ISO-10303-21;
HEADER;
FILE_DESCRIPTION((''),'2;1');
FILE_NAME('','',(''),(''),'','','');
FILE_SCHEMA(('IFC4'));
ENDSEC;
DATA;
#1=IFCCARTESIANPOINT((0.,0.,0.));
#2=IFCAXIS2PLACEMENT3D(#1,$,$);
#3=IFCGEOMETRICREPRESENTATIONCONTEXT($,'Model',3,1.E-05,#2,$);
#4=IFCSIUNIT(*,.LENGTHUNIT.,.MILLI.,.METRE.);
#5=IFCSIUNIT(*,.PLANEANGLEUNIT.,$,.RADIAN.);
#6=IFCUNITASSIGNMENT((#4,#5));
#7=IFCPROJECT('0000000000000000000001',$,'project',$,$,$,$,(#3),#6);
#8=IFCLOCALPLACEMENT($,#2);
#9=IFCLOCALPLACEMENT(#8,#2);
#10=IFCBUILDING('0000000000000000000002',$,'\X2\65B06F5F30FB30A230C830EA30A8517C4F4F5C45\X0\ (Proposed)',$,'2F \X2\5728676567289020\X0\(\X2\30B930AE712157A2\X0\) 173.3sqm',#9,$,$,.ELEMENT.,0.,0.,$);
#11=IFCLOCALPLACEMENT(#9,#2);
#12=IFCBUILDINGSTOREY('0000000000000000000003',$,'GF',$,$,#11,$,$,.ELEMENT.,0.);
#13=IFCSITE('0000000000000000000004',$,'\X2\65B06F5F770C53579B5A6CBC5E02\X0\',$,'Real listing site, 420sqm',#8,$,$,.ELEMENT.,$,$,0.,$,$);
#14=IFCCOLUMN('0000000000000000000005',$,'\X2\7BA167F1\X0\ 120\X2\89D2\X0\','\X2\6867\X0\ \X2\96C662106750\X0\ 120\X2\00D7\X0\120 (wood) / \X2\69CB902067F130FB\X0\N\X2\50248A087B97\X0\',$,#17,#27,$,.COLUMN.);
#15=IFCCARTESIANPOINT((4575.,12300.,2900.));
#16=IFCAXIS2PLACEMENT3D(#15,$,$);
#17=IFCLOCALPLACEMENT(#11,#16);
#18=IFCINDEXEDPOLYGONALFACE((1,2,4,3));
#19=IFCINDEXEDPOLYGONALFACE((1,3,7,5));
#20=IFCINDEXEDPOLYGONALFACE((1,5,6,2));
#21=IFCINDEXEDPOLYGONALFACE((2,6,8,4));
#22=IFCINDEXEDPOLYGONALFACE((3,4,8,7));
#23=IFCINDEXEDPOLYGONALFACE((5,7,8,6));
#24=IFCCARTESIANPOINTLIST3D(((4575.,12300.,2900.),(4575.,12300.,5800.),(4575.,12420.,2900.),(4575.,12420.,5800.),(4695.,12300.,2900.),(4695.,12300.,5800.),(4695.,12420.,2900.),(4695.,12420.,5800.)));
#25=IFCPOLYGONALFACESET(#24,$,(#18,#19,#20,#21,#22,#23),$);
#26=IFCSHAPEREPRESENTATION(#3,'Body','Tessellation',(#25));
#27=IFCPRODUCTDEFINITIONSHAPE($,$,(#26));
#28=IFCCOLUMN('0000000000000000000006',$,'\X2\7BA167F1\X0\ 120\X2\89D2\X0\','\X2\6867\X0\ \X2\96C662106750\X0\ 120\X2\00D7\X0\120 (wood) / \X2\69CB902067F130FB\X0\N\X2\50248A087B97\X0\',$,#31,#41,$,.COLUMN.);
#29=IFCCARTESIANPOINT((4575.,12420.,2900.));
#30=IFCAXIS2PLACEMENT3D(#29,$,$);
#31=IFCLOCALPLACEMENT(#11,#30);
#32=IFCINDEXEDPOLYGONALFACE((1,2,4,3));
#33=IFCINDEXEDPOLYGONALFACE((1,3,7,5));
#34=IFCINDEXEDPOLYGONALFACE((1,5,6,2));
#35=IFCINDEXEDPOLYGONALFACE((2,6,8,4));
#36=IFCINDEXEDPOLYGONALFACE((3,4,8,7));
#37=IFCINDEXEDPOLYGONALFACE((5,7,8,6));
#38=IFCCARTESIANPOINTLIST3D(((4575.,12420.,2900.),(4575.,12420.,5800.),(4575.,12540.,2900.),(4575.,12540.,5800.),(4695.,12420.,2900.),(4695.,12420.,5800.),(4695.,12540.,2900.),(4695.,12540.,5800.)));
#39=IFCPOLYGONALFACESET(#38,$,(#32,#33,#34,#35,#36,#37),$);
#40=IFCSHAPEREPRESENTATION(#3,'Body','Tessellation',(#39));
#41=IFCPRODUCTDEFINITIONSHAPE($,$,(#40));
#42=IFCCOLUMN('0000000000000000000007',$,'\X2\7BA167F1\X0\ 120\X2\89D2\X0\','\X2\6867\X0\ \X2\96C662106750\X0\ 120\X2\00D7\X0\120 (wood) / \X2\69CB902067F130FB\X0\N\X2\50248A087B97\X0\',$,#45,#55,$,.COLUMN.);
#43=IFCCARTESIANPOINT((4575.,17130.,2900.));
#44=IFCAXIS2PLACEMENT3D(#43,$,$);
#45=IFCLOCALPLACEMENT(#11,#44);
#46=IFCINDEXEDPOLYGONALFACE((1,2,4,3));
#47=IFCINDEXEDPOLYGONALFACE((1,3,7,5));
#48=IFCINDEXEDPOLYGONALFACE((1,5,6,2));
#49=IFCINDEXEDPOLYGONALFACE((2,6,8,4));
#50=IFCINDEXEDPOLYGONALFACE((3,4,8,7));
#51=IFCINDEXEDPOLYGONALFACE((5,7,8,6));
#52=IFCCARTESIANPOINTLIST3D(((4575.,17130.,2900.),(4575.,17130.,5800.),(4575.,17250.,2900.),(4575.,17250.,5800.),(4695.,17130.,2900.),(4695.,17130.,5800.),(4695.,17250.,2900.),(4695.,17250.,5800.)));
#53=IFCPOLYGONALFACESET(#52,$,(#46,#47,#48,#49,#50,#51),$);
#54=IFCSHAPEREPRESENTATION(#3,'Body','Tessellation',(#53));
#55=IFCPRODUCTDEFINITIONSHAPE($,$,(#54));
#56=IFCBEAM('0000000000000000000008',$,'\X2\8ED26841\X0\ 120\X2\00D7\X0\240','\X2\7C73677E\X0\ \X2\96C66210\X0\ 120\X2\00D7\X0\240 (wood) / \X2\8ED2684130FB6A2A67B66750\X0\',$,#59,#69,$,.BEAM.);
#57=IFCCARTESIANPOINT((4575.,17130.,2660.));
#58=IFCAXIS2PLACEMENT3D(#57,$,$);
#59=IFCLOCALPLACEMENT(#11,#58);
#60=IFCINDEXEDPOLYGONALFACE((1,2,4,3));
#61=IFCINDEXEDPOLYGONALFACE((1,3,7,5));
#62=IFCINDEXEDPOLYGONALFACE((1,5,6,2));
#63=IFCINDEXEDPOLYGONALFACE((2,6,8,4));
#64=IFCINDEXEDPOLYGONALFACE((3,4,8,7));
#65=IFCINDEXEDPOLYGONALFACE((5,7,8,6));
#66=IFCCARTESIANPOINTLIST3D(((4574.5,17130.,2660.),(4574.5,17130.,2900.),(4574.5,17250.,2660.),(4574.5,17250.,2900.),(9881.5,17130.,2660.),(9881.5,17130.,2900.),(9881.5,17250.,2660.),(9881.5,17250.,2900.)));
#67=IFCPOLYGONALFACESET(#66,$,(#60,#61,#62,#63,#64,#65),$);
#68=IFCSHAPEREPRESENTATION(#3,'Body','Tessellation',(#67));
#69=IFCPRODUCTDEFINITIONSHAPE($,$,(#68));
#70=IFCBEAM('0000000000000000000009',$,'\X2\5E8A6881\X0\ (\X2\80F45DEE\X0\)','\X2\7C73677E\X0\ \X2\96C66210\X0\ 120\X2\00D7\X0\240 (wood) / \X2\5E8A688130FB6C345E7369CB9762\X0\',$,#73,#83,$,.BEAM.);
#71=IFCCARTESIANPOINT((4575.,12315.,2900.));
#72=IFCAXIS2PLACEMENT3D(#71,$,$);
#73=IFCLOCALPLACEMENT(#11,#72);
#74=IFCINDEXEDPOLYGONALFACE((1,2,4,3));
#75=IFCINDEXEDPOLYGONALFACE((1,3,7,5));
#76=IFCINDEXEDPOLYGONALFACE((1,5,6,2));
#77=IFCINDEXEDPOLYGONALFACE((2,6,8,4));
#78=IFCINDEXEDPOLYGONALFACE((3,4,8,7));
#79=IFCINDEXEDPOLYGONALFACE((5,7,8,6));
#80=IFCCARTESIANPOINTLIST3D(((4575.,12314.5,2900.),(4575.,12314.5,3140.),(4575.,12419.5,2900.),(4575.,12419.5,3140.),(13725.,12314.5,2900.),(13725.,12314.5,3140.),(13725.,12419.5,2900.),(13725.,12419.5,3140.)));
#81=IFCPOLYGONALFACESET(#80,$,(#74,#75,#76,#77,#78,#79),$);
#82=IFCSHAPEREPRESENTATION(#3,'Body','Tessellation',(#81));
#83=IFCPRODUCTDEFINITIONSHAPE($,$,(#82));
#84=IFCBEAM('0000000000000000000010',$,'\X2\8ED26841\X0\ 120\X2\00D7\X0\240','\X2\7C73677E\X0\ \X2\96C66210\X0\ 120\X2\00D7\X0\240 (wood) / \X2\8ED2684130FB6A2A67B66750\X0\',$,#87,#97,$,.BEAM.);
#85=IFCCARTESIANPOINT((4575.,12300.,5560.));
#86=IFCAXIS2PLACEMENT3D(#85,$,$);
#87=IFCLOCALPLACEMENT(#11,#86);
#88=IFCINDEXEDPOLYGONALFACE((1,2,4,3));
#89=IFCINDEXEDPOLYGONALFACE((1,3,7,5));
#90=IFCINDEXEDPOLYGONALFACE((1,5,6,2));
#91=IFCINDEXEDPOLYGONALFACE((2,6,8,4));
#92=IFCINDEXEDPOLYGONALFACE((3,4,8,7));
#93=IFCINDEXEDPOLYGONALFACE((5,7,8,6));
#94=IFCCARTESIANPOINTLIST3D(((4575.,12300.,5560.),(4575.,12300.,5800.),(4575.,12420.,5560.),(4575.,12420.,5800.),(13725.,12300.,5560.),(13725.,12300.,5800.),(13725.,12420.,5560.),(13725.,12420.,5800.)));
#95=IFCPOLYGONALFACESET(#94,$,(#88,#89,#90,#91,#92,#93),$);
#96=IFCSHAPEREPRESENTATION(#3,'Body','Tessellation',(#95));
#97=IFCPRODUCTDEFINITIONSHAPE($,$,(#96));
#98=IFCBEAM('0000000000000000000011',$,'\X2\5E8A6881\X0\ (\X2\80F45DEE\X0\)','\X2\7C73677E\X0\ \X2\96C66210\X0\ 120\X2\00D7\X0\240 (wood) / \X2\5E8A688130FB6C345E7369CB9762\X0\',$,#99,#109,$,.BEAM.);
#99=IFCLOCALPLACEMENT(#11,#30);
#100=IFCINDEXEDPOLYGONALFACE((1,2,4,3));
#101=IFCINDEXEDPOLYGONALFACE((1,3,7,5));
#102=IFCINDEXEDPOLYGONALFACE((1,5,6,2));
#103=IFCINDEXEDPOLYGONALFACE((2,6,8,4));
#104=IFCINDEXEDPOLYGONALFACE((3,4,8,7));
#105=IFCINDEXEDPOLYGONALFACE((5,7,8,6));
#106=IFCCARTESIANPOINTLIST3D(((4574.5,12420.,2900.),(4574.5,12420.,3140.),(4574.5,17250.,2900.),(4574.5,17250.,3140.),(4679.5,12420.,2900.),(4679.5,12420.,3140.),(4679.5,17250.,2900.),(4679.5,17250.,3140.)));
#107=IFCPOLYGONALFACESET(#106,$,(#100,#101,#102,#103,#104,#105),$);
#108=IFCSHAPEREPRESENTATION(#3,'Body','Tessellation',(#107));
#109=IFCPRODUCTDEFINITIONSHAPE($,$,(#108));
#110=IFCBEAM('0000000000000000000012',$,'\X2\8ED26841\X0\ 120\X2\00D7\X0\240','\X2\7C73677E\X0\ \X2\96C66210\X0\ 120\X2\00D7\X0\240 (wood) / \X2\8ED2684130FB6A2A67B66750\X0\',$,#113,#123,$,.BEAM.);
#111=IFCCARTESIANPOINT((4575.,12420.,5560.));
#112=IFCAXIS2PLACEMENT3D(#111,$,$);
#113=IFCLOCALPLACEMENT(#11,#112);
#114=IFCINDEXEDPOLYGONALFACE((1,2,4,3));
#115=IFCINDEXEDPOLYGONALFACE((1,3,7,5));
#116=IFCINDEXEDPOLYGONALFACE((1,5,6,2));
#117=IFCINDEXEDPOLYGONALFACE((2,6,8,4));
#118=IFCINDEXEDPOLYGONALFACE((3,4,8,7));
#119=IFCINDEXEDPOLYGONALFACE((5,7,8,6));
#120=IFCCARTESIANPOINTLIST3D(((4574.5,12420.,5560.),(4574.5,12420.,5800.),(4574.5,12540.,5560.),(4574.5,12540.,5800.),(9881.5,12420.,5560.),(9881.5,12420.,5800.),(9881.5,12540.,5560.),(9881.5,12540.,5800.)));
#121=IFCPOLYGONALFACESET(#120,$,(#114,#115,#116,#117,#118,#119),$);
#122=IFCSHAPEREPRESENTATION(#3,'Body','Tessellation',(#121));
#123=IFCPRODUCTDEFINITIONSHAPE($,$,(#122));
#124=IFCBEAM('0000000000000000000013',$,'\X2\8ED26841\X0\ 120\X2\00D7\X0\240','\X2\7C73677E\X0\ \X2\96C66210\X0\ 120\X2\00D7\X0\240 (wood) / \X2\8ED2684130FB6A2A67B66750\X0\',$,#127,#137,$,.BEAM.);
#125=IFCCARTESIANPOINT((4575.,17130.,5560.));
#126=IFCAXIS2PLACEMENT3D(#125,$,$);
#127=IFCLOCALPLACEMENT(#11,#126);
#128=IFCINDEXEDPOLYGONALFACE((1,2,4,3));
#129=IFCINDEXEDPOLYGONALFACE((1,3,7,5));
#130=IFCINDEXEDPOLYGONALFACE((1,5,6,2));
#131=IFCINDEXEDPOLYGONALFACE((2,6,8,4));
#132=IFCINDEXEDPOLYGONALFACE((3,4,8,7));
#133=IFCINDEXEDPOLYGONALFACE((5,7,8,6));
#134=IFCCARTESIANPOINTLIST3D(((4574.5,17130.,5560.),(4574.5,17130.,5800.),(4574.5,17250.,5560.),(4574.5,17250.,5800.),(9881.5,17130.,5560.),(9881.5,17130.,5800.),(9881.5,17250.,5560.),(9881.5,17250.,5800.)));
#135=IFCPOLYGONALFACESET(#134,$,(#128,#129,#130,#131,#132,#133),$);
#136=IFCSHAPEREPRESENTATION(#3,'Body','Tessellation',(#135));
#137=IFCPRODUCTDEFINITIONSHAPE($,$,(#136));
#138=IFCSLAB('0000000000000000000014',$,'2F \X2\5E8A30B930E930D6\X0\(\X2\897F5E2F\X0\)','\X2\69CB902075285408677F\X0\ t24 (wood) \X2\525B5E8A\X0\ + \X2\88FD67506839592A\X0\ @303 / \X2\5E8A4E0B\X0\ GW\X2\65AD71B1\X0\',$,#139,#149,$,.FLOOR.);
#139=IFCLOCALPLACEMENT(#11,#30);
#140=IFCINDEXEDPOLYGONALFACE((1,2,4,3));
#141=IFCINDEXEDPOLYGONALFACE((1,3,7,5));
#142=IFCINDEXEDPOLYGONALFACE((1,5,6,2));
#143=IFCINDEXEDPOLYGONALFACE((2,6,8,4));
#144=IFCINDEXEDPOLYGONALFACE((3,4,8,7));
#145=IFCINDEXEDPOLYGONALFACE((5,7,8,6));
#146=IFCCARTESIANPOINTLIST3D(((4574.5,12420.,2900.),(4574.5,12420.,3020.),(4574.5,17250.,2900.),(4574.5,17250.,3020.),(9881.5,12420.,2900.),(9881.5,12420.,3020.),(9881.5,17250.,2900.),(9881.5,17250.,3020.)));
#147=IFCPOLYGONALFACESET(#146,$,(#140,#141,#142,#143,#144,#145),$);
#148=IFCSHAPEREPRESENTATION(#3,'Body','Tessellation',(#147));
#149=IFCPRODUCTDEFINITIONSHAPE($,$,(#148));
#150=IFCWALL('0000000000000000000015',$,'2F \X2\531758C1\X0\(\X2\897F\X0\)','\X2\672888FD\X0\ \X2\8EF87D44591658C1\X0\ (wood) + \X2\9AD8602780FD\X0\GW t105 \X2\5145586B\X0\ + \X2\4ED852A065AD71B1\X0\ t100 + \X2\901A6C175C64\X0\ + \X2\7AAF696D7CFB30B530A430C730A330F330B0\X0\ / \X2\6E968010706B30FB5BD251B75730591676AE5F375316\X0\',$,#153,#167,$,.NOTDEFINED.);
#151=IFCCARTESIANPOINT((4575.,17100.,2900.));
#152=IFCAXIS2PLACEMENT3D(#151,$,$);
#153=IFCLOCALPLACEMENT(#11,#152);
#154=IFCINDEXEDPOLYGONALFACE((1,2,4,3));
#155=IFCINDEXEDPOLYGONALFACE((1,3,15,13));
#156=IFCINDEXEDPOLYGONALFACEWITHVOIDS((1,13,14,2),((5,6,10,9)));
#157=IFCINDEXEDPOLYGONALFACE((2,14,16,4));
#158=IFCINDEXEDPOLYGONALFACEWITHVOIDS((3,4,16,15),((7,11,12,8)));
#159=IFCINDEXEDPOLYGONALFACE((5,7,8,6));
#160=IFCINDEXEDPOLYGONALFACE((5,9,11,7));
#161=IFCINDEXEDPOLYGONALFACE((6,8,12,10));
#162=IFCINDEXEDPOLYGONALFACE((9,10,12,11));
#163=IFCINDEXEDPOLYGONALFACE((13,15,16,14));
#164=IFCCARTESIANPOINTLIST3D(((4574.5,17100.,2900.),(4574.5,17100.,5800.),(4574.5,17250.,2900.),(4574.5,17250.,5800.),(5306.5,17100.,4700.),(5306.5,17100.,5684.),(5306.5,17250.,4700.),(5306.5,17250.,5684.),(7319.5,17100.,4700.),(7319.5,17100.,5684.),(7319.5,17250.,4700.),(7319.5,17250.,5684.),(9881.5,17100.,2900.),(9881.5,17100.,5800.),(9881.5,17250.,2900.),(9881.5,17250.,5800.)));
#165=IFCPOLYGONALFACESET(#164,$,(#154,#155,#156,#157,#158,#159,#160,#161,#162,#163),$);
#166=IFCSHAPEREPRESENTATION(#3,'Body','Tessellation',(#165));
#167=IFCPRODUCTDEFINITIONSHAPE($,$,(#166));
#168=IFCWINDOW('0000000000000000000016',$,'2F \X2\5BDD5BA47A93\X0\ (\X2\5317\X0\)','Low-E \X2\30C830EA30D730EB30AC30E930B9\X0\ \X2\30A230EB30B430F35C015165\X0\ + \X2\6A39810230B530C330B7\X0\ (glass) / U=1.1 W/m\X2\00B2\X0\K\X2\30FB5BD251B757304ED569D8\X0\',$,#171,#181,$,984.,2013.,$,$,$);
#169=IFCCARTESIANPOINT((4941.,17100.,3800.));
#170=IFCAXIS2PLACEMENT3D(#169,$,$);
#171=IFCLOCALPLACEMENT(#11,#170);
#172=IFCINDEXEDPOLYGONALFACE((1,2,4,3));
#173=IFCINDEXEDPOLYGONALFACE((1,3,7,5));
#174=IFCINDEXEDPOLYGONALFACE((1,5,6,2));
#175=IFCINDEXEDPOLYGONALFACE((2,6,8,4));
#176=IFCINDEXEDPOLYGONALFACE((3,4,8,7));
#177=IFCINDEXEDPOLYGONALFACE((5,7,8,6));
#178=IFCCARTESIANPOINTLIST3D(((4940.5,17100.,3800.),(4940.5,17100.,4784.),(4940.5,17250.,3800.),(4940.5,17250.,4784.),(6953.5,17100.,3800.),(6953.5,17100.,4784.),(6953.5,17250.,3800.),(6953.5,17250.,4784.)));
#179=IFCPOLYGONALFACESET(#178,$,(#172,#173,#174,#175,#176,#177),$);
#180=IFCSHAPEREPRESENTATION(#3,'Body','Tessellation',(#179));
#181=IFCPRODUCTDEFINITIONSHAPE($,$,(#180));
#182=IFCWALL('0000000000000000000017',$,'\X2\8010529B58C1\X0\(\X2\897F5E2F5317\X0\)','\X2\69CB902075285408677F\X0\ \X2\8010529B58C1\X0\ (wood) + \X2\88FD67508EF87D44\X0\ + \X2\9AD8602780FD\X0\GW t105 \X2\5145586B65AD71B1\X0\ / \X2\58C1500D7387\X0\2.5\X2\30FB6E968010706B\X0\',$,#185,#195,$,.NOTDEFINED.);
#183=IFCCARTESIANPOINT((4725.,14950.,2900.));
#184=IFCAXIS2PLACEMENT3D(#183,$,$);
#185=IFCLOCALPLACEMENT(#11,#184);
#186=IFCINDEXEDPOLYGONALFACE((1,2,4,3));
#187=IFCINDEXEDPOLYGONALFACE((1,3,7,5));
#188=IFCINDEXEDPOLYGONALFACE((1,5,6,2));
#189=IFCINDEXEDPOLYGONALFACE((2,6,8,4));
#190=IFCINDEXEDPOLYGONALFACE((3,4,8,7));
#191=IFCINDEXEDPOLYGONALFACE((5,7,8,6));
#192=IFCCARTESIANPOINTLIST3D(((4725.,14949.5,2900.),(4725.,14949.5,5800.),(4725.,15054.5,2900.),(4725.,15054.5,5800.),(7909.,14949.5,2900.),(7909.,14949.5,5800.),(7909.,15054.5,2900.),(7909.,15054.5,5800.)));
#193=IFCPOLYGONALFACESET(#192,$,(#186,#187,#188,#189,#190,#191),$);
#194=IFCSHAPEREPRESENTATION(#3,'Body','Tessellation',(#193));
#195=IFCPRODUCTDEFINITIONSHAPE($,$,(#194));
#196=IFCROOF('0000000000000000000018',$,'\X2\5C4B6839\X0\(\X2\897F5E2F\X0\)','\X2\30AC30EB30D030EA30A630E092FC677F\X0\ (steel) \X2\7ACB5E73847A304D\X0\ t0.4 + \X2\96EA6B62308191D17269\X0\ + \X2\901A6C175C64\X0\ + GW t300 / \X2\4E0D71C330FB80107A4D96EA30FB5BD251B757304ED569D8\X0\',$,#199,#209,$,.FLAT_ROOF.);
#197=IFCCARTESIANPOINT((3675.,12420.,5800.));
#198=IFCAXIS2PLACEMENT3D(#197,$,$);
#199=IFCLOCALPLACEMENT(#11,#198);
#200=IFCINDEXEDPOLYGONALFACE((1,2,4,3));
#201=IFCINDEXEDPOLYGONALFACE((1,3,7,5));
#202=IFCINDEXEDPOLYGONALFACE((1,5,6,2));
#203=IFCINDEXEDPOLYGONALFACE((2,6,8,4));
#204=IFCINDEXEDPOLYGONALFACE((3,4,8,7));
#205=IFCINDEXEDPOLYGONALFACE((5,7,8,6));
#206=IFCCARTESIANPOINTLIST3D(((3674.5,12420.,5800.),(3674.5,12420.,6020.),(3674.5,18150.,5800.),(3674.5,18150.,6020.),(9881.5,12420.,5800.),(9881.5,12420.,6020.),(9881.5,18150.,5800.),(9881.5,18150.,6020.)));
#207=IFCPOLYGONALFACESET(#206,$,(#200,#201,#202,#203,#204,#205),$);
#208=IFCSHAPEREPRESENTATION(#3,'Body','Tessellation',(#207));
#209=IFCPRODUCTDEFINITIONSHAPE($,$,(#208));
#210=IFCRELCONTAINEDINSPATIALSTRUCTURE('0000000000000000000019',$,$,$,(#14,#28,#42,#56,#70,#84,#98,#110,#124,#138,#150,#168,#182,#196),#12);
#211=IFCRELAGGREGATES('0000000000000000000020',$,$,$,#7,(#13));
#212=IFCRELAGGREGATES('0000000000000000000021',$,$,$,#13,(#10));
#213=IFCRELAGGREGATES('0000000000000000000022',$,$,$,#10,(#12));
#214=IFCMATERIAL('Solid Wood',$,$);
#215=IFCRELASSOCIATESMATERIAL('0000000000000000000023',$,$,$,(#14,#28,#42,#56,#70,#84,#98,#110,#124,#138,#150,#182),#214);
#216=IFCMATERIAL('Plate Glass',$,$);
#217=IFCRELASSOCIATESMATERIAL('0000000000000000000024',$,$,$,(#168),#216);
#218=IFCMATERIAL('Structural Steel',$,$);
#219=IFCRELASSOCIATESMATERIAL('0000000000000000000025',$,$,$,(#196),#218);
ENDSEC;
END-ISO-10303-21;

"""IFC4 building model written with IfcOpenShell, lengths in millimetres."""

from ifc_helpers import new_model, si_unit, frame, frame_2d, origin, place, context, project, spatial, rectangle, extrude, material, element, fill, save


model = new_model("IFC4")

# Units and contexts
model_context = context("Model", 3, precision=1e-05, world=origin())
ifc_project = project(units=[si_unit("LENGTHUNIT", "METRE", prefix="MILLI"), si_unit("PLANEANGLEUNIT", "RADIAN")], contexts=[model_context])

# Site, building, storey
site_placement = place(None, origin())
site = spatial("IfcSite", under=ifc_project, at=site_placement, Name="新潟県南魚沼市", ObjectType="Real listing site, 420sqm", CompositionType="ELEMENT", RefElevation=0.0)
building_placement = place(site_placement, origin())
building = spatial("IfcBuilding", under=site, at=building_placement, Name="新潟・アトリエ兼住居 (Proposed)", ObjectType="2F 在来木造(スギ無垢) 173.3sqm", CompositionType="ELEMENT", ElevationOfRefHeight=0.0, ElevationOfTerrain=0.0)
storey_placement = place(building_placement, origin())
storey = spatial("IfcBuildingStorey", under=building, at=storey_placement, Name="GF", CompositionType="ELEMENT", Elevation=0.0)

# Columns
ifc_material_1 = material(Name="Solid Wood")
column_1_placement = place(storey_placement, frame((4575.0, 12300.0, 2900.0)))
element("IfcColumn", 1, at=column_1_placement, inside=storey, material=ifc_material_1, Name="管柱 120角", Description="桧 集成材 120×120 (wood) / 構造柱・N値計算", PredefinedType="COLUMN", context=model_context, shape_type="SweptSolid", body=[
    extrude(rectangle(XDim=120.0, YDim=120.0, at=frame_2d((60.0, 60.0))), frame((4575.0, 12300.0, 2900.0)), (0.0, 0.0, 1.0), 2900.0),
])
column_2_placement = place(storey_placement, frame((4575.0, 12420.0, 2900.0)))
element("IfcColumn", 2, at=column_2_placement, inside=storey, material=ifc_material_1, Name="管柱 120角", Description="桧 集成材 120×120 (wood) / 構造柱・N値計算", PredefinedType="COLUMN", context=model_context, shape_type="SweptSolid", body=[
    extrude(rectangle(XDim=120.0, YDim=120.0, at=frame_2d((60.0, 60.0))), frame((4575.0, 12420.0, 2900.0)), (0.0, 0.0, 1.0), 2900.0),
])
column_3_placement = place(storey_placement, frame((4575.0, 17130.0, 2900.0)))
element("IfcColumn", 3, at=column_3_placement, inside=storey, material=ifc_material_1, Name="管柱 120角", Description="桧 集成材 120×120 (wood) / 構造柱・N値計算", PredefinedType="COLUMN", context=model_context, shape_type="SweptSolid", body=[
    extrude(rectangle(XDim=120.0, YDim=120.0, at=frame_2d((60.0, 60.0))), frame((4575.0, 17130.0, 2900.0)), (0.0, 0.0, 1.0), 2900.0),
])

# Beams
beam_1_placement = place(storey_placement, frame((4575.0, 17130.0, 2660.0)))
element("IfcBeam", 4, at=beam_1_placement, inside=storey, material=ifc_material_1, Name="軒桁 120×240", Description="米松 集成 120×240 (wood) / 軒桁・横架材", PredefinedType="BEAM", context=model_context, shape_type="SweptSolid", body=[
    extrude(rectangle(XDim=5307.0, YDim=120.0, at=frame_2d((2653.0, 60.0))), frame((4575.0, 17130.0, 2660.0)), (0.0, 0.0, 1.0), 240.0),
])
beam_2_placement = place(storey_placement, frame((4575.0, 12315.0, 2900.0)))
element("IfcBeam", 5, at=beam_2_placement, inside=storey, material=ifc_material_1, Name="床梁 (胴差)", Description="米松 集成 120×240 (wood) / 床梁・水平構面", PredefinedType="BEAM", context=model_context, shape_type="SweptSolid", body=[
    extrude(rectangle(XDim=9150.0, YDim=105.0, at=frame_2d((4575.0, 52.0))), frame((4575.0, 12315.0, 2900.0)), (0.0, 0.0, 1.0), 240.0),
])
beam_3_placement = place(storey_placement, frame((4575.0, 12300.0, 5560.0)))
element("IfcBeam", 6, at=beam_3_placement, inside=storey, material=ifc_material_1, Name="軒桁 120×240", Description="米松 集成 120×240 (wood) / 軒桁・横架材", PredefinedType="BEAM", context=model_context, shape_type="SweptSolid", body=[
    extrude(rectangle(XDim=9150.0, YDim=120.0, at=frame_2d((4575.0, 60.0))), frame((4575.0, 12300.0, 5560.0)), (0.0, 0.0, 1.0), 240.0),
])
beam_4_placement = place(storey_placement, frame((4575.0, 12420.0, 2900.0)))
element("IfcBeam", 7, at=beam_4_placement, inside=storey, material=ifc_material_1, Name="床梁 (胴差)", Description="米松 集成 120×240 (wood) / 床梁・水平構面", PredefinedType="BEAM", context=model_context, shape_type="SweptSolid", body=[
    extrude(rectangle(XDim=105.0, YDim=4830.0, at=frame_2d((52.0, 2415.0))), frame((4575.0, 12420.0, 2900.0)), (0.0, 0.0, 1.0), 240.0),
])
beam_5_placement = place(storey_placement, frame((4575.0, 12420.0, 5560.0)))
element("IfcBeam", 8, at=beam_5_placement, inside=storey, material=ifc_material_1, Name="軒桁 120×240", Description="米松 集成 120×240 (wood) / 軒桁・横架材", PredefinedType="BEAM", context=model_context, shape_type="SweptSolid", body=[
    extrude(rectangle(XDim=5307.0, YDim=120.0, at=frame_2d((2653.0, 60.0))), frame((4575.0, 12420.0, 5560.0)), (0.0, 0.0, 1.0), 240.0),
])
beam_6_placement = place(storey_placement, frame((4575.0, 17130.0, 5560.0)))
element("IfcBeam", 9, at=beam_6_placement, inside=storey, material=ifc_material_1, Name="軒桁 120×240", Description="米松 集成 120×240 (wood) / 軒桁・横架材", PredefinedType="BEAM", context=model_context, shape_type="SweptSolid", body=[
    extrude(rectangle(XDim=5307.0, YDim=120.0, at=frame_2d((2653.0, 60.0))), frame((4575.0, 17130.0, 5560.0)), (0.0, 0.0, 1.0), 240.0),
])

# Slab
slab_placement = place(storey_placement, frame((4575.0, 12420.0, 2900.0)))
element("IfcSlab", 10, at=slab_placement, inside=storey, material=ifc_material_1, Name="2F 床スラブ(西帯)", Description="構造用合板 t24 (wood) 剛床 + 製材根太 @303 / 床下 GW断熱", PredefinedType="FLOOR", context=model_context, shape_type="SweptSolid", body=[
    extrude(rectangle(XDim=5307.0, YDim=4830.0, at=frame_2d((2653.0, 2415.0))), frame((4575.0, 12420.0, 2900.0)), (0.0, 0.0, 1.0), 120.0),
])

# Wall, opening, window
wall_1_placement = place(storey_placement, frame((4575.0, 17100.0, 2900.0)))
wall_1 = element("IfcWall", 11, at=wall_1_placement, inside=storey, material=ifc_material_1, Name="2F 北壁(西)", Description="木製 軸組外壁 (wood) + 高性能GW t105 充填 + 付加断熱 t100 + 通気層 + 窯業系サイディング / 準耐火・寒冷地外皮強化", PredefinedType="NOTDEFINED", context=model_context, shape_type="SweptSolid", body=[
    extrude(rectangle(XDim=5307.0, YDim=150.0, at=frame_2d((2653.0, 75.0))), frame((4575.0, 17100.0, 2900.0)), (0.0, 0.0, 1.0), 2900.0),
])
opening_placement = place(storey_placement, frame((4941.0, 17100.0, 3800.0)))
opening = element("IfcOpeningElement", 12, at=opening_placement, cuts=wall_1, PredefinedType="NOTDEFINED", context=model_context, shape_type="SweptSolid", body=[
    extrude(rectangle(XDim=2013.0, YDim=150.0, at=frame_2d((1006.0, 75.0))), frame((4941.0, 17100.0, 3800.0)), (0.0, 0.0, 1.0), 984.0),
])
ifc_material_2 = material(Name="Plate Glass")
window_placement = place(storey_placement, frame((4941.0, 17100.0, 3800.0)))
window = element("IfcWindow", 13, at=window_placement, inside=storey, material=ifc_material_2, Name="2F 寝室窓 (北)", Description="Low-E トリプルガラス アルゴン封入 + 樹脂サッシ (glass) / U=1.1 W/m²K・寒冷地仕様", OverallHeight=984.0, OverallWidth=2013.0, context=model_context, shape_type="SweptSolid", body=[
    extrude(rectangle(XDim=2013.0, YDim=150.0, at=frame_2d((1006.0, 75.0))), frame((4941.0, 17100.0, 3800.0)), (0.0, 0.0, 1.0), 984.0),
])
fill(opening, window)

# Wall
wall_2_placement = place(storey_placement, frame((4725.0, 14950.0, 2900.0)))
element("IfcWall", 14, at=wall_2_placement, inside=storey, material=ifc_material_1, Name="耐力壁(西帯北)", Description="構造用合板 耐力壁 (wood) + 製材軸組 + 高性能GW t105 充填断熱 / 壁倍率2.5・準耐火", PredefinedType="NOTDEFINED", context=model_context, shape_type="SweptSolid", body=[
    extrude(rectangle(XDim=3184.0, YDim=105.0, at=frame_2d((1592.0, 52.0))), frame((4725.0, 14950.0, 2900.0)), (0.0, 0.0, 1.0), 2900.0),
])

# Roof
ifc_material_3 = material(Name="Structural Steel")
for number, where, name in (
    (15, (3675.0, 12420.0, 5800.0), "屋根(西帯)"),
):
    element("IfcRoof", number, at=place(storey_placement, frame(where)), inside=storey, material=ifc_material_3, Name=name, Description="ガルバリウム鋼板 (steel) 立平葺き t0.4 + 雪止め金物 + 通気層 + GW t300 / 不燃・耐積雪・寒冷地仕様", PredefinedType="FLAT_ROOF", context=model_context, shape_type="SweptSolid", body=[
        extrude(rectangle(XDim=6207.0, YDim=5730.0, at=frame_2d((3103.0, 2865.0))), frame((3675.0, 12420.0, 5800.0)), (0.0, 0.0, 1.0), 220.0),
    ])

save(model, "model.ifc")
